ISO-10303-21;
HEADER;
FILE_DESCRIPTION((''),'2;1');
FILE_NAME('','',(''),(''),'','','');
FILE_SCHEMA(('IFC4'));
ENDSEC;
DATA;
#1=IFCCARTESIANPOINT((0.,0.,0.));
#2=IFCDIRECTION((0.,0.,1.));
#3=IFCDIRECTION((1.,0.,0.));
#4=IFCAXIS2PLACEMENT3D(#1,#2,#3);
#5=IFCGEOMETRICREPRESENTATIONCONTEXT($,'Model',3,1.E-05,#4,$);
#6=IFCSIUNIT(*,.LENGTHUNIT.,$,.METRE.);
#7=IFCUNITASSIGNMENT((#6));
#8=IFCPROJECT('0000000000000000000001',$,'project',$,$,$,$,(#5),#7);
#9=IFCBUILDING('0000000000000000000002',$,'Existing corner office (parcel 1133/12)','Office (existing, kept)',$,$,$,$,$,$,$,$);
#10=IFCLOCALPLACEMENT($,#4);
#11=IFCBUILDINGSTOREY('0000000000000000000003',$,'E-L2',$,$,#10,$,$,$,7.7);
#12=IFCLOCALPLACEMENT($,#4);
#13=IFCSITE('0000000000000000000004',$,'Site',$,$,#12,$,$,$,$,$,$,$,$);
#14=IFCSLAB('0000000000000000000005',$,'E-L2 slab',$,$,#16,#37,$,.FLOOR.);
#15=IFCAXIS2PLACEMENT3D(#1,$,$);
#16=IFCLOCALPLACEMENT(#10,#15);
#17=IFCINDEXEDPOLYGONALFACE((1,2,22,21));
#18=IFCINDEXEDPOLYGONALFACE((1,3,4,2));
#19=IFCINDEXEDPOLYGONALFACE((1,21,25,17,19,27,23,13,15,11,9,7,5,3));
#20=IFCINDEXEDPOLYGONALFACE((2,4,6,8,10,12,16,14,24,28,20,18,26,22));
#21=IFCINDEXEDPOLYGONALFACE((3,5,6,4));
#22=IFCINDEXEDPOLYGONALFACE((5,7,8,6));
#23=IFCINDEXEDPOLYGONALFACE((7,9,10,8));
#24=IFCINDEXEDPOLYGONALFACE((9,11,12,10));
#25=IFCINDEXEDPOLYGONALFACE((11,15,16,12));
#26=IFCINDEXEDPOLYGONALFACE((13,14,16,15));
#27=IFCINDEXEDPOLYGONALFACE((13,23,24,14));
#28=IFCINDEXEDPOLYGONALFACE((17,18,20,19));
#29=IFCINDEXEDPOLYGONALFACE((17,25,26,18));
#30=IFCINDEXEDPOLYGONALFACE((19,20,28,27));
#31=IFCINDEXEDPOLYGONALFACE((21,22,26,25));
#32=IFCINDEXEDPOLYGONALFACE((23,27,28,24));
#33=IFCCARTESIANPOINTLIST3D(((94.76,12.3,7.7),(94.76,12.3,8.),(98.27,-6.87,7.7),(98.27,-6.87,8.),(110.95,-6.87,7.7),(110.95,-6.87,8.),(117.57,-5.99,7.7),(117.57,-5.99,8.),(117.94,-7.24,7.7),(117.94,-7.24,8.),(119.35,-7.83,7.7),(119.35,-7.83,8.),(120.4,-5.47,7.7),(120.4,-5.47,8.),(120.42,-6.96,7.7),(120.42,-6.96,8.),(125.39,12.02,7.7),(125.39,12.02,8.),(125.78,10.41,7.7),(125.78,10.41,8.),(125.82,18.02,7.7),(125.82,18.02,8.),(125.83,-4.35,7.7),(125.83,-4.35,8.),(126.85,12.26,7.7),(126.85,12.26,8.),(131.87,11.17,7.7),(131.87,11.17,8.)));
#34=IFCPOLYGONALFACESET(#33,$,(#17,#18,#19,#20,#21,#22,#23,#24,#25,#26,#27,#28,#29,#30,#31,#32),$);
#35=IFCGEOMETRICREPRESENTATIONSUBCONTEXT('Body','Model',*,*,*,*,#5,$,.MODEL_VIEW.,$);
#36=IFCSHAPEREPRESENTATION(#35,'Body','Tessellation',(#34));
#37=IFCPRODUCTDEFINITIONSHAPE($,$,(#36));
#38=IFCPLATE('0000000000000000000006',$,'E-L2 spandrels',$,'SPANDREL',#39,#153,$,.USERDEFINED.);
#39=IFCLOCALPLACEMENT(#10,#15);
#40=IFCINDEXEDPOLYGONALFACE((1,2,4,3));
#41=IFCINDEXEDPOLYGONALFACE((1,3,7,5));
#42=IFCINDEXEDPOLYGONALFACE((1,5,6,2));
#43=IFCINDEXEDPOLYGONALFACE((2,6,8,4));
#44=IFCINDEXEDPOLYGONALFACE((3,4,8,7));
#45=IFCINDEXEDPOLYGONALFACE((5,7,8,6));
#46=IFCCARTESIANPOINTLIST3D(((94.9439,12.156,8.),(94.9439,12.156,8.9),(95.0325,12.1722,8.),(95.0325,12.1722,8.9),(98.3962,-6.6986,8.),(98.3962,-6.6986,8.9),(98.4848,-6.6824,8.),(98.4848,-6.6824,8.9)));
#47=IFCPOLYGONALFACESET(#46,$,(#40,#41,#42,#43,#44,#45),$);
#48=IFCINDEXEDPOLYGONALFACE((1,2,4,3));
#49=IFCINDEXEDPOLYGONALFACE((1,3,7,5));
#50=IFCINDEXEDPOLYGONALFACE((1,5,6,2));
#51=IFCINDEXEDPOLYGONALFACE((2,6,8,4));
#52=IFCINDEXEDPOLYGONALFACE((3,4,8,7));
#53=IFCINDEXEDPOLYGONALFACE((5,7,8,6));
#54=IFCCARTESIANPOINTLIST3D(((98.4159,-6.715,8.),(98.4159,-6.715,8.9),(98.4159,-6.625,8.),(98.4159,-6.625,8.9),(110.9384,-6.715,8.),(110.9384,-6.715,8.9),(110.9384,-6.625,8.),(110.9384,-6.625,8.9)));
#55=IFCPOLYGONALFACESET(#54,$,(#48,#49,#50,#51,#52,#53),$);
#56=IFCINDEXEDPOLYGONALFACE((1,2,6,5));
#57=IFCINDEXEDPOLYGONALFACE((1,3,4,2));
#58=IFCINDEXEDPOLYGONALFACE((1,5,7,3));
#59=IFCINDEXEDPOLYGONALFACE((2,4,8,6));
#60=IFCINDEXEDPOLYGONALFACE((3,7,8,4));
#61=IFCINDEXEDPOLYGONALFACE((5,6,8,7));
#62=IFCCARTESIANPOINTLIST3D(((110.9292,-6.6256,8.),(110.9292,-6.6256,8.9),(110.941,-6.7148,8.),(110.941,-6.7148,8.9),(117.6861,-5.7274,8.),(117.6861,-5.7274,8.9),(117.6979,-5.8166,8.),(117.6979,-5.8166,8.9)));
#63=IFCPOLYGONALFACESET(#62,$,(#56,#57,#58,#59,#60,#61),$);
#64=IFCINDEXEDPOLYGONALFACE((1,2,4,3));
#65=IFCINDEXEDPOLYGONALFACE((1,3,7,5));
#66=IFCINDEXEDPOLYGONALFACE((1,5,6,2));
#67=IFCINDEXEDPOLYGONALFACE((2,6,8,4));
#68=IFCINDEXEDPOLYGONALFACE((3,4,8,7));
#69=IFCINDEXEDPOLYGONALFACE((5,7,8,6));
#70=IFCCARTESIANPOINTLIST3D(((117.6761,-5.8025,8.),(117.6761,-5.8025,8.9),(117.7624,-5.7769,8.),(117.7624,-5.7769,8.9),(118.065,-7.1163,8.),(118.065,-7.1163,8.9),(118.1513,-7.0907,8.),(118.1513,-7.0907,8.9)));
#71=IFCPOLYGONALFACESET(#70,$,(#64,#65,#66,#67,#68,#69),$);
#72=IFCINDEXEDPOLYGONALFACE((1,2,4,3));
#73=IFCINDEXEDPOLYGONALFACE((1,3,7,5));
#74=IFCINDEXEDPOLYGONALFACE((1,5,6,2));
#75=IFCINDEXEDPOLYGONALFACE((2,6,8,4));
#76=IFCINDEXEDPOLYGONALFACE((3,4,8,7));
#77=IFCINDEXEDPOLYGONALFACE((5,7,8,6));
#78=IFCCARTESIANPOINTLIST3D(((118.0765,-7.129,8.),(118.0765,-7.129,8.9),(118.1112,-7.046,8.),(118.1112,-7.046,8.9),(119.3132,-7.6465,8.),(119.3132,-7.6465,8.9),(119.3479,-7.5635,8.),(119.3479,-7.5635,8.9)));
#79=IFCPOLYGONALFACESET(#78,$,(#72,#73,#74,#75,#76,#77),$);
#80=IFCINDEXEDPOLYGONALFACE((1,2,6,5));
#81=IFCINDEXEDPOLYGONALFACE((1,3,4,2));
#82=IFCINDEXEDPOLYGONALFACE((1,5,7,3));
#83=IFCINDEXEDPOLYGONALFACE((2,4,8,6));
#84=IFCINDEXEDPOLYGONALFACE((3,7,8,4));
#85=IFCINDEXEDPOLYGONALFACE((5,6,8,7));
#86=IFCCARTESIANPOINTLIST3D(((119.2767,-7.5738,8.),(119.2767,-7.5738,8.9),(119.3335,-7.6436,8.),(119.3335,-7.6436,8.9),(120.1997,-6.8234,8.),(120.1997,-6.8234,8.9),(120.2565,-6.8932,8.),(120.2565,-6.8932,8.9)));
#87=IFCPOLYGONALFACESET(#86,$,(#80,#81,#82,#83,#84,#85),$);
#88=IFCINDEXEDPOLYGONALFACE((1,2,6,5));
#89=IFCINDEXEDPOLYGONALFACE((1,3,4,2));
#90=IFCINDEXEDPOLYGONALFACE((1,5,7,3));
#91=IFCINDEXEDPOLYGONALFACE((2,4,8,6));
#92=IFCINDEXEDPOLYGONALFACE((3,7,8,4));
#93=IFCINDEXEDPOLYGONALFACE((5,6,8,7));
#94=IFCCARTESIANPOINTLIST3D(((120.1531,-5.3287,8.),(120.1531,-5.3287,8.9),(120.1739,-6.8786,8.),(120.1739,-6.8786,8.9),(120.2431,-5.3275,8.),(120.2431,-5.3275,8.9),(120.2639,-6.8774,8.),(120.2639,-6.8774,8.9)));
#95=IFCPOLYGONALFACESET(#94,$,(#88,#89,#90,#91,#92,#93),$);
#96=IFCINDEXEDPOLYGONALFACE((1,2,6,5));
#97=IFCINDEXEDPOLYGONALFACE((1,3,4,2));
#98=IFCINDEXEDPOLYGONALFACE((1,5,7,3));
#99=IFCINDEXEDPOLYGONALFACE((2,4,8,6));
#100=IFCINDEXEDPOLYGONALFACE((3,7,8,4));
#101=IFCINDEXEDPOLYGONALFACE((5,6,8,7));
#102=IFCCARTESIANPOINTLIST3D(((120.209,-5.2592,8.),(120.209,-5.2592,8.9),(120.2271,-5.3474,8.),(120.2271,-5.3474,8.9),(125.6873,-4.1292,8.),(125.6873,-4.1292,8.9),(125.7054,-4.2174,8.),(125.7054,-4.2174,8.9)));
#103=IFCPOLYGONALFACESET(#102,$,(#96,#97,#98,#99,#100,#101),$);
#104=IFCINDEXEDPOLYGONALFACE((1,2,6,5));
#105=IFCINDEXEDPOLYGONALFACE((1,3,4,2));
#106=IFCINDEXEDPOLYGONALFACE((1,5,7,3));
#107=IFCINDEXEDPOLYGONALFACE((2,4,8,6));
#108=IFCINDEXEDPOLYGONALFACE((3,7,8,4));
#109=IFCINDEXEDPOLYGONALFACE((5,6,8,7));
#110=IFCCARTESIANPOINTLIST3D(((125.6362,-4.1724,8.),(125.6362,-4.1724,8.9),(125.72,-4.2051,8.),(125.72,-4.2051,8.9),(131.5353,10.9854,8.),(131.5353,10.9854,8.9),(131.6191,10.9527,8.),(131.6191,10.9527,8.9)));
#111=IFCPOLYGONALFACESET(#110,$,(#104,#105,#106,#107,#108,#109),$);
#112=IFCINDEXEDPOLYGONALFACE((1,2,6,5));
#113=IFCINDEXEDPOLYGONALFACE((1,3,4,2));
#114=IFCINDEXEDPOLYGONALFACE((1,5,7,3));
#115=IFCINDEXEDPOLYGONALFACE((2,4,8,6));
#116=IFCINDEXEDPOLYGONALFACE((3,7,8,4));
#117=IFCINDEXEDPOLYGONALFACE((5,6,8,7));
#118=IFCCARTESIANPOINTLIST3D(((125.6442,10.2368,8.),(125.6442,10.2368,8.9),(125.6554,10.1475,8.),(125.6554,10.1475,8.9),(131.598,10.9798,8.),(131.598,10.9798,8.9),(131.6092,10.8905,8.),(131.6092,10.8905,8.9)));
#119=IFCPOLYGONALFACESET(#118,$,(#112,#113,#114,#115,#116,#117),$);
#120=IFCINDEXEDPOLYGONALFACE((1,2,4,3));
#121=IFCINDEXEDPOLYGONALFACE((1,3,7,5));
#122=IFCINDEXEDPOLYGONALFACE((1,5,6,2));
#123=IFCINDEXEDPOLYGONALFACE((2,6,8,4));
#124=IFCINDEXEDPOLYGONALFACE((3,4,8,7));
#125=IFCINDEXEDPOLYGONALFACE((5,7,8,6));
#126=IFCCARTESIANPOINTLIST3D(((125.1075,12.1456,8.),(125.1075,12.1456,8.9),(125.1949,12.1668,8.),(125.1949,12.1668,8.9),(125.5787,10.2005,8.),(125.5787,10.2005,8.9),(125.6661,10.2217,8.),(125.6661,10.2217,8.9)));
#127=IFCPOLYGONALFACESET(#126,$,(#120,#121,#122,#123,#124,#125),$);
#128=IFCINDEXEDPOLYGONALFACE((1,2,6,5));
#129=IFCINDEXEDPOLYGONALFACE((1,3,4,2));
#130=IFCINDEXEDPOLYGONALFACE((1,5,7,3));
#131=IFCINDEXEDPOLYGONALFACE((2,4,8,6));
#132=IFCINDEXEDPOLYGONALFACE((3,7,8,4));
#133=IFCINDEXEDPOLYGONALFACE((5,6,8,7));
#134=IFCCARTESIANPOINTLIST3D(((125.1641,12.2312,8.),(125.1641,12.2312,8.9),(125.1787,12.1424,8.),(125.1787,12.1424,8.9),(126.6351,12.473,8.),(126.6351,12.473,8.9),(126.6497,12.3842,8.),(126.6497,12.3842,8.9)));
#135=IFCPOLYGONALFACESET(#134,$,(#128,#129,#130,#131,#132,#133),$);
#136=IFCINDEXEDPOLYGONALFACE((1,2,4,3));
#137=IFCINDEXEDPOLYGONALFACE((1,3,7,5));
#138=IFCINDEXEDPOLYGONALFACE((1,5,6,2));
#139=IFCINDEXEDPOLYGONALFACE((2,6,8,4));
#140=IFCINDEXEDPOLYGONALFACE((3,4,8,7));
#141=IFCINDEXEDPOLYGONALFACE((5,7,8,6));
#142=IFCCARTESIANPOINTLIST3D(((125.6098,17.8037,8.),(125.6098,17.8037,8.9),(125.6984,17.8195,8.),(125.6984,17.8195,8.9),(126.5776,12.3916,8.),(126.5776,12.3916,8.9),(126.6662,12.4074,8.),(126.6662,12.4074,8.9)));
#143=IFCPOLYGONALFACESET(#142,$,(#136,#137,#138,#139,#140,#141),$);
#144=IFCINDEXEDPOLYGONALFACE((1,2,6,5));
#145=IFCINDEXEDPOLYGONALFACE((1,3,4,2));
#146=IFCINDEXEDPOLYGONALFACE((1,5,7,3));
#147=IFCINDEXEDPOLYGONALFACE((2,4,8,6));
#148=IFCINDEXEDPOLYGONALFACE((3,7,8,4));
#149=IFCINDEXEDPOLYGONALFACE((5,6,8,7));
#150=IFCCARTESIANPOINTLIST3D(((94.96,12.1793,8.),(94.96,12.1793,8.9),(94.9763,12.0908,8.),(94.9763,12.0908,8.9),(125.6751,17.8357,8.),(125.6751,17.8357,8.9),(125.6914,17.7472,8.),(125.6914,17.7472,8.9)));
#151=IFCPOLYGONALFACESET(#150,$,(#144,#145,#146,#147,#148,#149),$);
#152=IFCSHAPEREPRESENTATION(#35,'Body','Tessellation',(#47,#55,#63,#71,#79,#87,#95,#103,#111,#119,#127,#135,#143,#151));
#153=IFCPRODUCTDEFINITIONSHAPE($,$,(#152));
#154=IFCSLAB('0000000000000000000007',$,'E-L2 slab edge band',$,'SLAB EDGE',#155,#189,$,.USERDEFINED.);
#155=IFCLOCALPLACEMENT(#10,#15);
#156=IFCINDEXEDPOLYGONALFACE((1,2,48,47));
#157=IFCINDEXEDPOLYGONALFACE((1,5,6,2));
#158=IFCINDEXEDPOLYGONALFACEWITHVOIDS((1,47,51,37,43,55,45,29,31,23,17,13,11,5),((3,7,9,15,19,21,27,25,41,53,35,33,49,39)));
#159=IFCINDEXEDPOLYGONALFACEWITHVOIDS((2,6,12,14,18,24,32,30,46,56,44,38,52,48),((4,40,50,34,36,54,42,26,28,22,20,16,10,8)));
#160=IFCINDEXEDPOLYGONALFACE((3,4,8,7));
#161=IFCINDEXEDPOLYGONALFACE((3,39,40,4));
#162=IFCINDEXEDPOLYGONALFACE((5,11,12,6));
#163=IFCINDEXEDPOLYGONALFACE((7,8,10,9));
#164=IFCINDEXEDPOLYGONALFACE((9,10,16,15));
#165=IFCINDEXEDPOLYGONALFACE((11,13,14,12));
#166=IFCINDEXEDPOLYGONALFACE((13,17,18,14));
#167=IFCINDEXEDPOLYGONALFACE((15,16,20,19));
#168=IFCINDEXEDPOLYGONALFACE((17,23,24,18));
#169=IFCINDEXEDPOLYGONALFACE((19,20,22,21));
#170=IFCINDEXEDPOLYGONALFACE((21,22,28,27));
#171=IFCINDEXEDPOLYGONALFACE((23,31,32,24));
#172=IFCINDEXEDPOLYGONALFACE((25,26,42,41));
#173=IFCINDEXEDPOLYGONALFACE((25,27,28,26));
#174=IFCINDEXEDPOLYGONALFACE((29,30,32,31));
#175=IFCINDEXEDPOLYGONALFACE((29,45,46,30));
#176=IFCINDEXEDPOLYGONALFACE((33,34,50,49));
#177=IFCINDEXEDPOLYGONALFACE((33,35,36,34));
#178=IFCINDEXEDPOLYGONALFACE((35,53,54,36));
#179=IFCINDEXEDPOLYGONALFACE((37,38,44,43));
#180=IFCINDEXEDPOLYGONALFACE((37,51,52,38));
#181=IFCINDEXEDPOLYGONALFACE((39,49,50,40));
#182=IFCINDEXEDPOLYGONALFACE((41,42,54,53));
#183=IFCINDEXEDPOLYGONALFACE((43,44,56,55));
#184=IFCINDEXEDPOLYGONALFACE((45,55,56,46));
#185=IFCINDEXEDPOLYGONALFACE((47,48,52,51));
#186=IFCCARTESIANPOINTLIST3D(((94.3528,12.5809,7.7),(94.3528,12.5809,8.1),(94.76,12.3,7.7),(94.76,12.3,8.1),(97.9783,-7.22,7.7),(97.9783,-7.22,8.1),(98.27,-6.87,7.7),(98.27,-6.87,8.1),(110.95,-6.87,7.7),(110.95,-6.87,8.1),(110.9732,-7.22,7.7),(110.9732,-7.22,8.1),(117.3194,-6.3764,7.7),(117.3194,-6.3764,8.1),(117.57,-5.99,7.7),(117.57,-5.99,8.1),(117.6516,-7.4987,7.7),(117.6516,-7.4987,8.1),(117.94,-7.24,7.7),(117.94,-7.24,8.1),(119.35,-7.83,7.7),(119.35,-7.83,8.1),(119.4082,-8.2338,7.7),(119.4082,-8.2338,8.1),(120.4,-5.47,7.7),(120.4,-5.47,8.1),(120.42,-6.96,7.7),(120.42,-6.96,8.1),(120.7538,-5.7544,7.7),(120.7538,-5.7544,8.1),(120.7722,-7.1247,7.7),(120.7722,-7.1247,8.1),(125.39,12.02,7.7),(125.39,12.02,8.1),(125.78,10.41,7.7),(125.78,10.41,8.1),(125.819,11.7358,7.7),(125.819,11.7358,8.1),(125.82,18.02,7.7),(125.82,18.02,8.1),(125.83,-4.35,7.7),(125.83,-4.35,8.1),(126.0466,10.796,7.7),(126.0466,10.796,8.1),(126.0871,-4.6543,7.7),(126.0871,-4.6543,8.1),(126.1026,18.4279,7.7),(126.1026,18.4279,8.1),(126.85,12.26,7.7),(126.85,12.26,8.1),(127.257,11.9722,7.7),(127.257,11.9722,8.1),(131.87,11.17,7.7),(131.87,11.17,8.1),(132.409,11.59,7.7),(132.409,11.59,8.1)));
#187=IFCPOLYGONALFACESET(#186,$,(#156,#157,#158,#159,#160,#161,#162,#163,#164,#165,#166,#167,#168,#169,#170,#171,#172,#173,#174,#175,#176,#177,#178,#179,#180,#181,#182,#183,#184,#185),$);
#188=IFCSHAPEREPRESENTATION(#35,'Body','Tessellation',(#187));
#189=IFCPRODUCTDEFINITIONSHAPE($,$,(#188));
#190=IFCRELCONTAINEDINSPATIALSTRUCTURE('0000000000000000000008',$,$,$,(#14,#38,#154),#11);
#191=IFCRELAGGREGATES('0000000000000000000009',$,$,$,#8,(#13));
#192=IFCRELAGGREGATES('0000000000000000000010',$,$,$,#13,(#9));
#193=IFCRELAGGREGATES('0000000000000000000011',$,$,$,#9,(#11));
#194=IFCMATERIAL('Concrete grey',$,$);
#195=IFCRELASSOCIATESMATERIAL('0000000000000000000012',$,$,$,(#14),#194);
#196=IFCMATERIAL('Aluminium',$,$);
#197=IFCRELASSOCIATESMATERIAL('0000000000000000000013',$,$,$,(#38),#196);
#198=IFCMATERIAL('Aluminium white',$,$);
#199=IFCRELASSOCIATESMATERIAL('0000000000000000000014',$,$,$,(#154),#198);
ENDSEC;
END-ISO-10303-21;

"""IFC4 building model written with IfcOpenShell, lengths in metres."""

from ifc_helpers import new_model, si_unit, frame, origin_with_axes, place, context, subcontext, project, spatial, polyline, outline, extrude, material, element, save


model = new_model("IFC4")

# Units and contexts
model_context = context("Model", 3, precision=1e-05, world=origin_with_axes())
body_context = subcontext(model_context, "Body", "Model", "MODEL_VIEW")
ifc_project = project(units=[si_unit("LENGTHUNIT", "METRE")], contexts=[model_context])

# Site, building, storey
site_placement = place(None, origin_with_axes())
site = spatial("IfcSite", under=ifc_project, at=site_placement, Name="Site")
building = spatial("IfcBuilding", under=site, Name="Existing corner office (parcel 1133/12)", Description="Office (existing, kept)")
storey_placement = place(None, origin_with_axes())
storey = spatial("IfcBuildingStorey", under=building, at=storey_placement, Name="E-L2", Elevation=7.7)

# Shared definitions
ifc_material_1 = material(Name="Aluminium")

# Slab
ifc_material_2 = material(Name="Concrete grey")
slab_1_placement = place(storey_placement, origin_with_axes())
element("IfcSlab", 1, at=slab_1_placement, inside=storey, material=ifc_material_2, Name="E-L2 slab", PredefinedType="FLOOR", context=body_context, shape_type="SweptSolid", body=[
    extrude(outline(polyline([(94.76, 12.3), (98.27, -6.87), (110.95, -6.87), (117.57, -5.99), (117.94, -7.24), (119.35, -7.83), (120.42, -6.96), (120.4, -5.47), (125.83, -4.35), (131.87, 11.17), (125.78, 10.41), (125.39, 12.02), (126.85, 12.26), (125.82, 18.02), (94.76, 12.3)])), frame((0.0, 0.0, 7.7), z_axis=(0.0, 0.0, 1.0), x_axis=(1.0, 0.0, 0.0)), (0.0, 0.0, 1.0), 0.3),
])

# Plate
plate_placement = place(storey_placement, origin_with_axes())
element("IfcPlate", 2, at=plate_placement, inside=storey, material=ifc_material_1, Name="E-L2 spandrels", ObjectType="SPANDREL", PredefinedType="USERDEFINED", context=body_context, shape_type="SweptSolid", body=[
    extrude(outline(polyline([(94.9439, 12.156), (98.3962, -6.6986), (98.4848, -6.6824), (95.0325, 12.1722), (94.9439, 12.156)])), frame((0.0, 0.0, 8.0), z_axis=(0.0, 0.0, 1.0), x_axis=(1.0, 0.0, 0.0)), (0.0, 0.0, 1.0), 0.9),
    extrude(outline(polyline([(98.4159, -6.715), (110.9384, -6.715), (110.9384, -6.625), (98.4159, -6.625), (98.4159, -6.715)])), frame((0.0, 0.0, 8.0), z_axis=(0.0, 0.0, 1.0), x_axis=(1.0, 0.0, 0.0)), (0.0, 0.0, 1.0), 0.9),
    extrude(outline(polyline([(110.941, -6.7148), (117.6979, -5.8166), (117.6861, -5.7274), (110.9292, -6.6256), (110.941, -6.7148)])), frame((0.0, 0.0, 8.0), z_axis=(0.0, 0.0, 1.0), x_axis=(1.0, 0.0, 0.0)), (0.0, 0.0, 1.0), 0.9),
    extrude(outline(polyline([(117.6761, -5.8025), (118.065, -7.1163), (118.1513, -7.0907), (117.7624, -5.7769), (117.6761, -5.8025)])), frame((0.0, 0.0, 8.0), z_axis=(0.0, 0.0, 1.0), x_axis=(1.0, 0.0, 0.0)), (0.0, 0.0, 1.0), 0.9),
    extrude(outline(polyline([(118.0765, -7.129), (119.3132, -7.6465), (119.3479, -7.5635), (118.1112, -7.046), (118.0765, -7.129)])), frame((0.0, 0.0, 8.0), z_axis=(0.0, 0.0, 1.0), x_axis=(1.0, 0.0, 0.0)), (0.0, 0.0, 1.0), 0.9),
    extrude(outline(polyline([(119.3335, -7.6436), (120.2565, -6.8932), (120.1997, -6.8234), (119.2767, -7.5738), (119.3335, -7.6436)])), frame((0.0, 0.0, 8.0), z_axis=(0.0, 0.0, 1.0), x_axis=(1.0, 0.0, 0.0)), (0.0, 0.0, 1.0), 0.9),
    extrude(outline(polyline([(120.2639, -6.8774), (120.2431, -5.3275), (120.1531, -5.3287), (120.1739, -6.8786), (120.2639, -6.8774)])), frame((0.0, 0.0, 8.0), z_axis=(0.0, 0.0, 1.0), x_axis=(1.0, 0.0, 0.0)), (0.0, 0.0, 1.0), 0.9),
    extrude(outline(polyline([(120.2271, -5.3474), (125.7054, -4.2174), (125.6873, -4.1292), (120.209, -5.2592), (120.2271, -5.3474)])), frame((0.0, 0.0, 8.0), z_axis=(0.0, 0.0, 1.0), x_axis=(1.0, 0.0, 0.0)), (0.0, 0.0, 1.0), 0.9),
    extrude(outline(polyline([(125.72, -4.2051), (131.6191, 10.9527), (131.5353, 10.9854), (125.6362, -4.1724), (125.72, -4.2051)])), frame((0.0, 0.0, 8.0), z_axis=(0.0, 0.0, 1.0), x_axis=(1.0, 0.0, 0.0)), (0.0, 0.0, 1.0), 0.9),
    extrude(outline(polyline([(131.598, 10.9798), (125.6442, 10.2368), (125.6554, 10.1475), (131.6092, 10.8905), (131.598, 10.9798)])), frame((0.0, 0.0, 8.0), z_axis=(0.0, 0.0, 1.0), x_axis=(1.0, 0.0, 0.0)), (0.0, 0.0, 1.0), 0.9),
    extrude(outline(polyline([(125.6661, 10.2217), (125.1949, 12.1668), (125.1075, 12.1456), (125.5787, 10.2005), (125.6661, 10.2217)])), frame((0.0, 0.0, 8.0), z_axis=(0.0, 0.0, 1.0), x_axis=(1.0, 0.0, 0.0)), (0.0, 0.0, 1.0), 0.9),
    extrude(outline(polyline([(125.1787, 12.1424), (126.6497, 12.3842), (126.6351, 12.473), (125.1641, 12.2312), (125.1787, 12.1424)])), frame((0.0, 0.0, 8.0), z_axis=(0.0, 0.0, 1.0), x_axis=(1.0, 0.0, 0.0)), (0.0, 0.0, 1.0), 0.9),
    extrude(outline(polyline([(126.6662, 12.4074), (125.6984, 17.8195), (125.6098, 17.8037), (126.5776, 12.3916), (126.6662, 12.4074)])), frame((0.0, 0.0, 8.0), z_axis=(0.0, 0.0, 1.0), x_axis=(1.0, 0.0, 0.0)), (0.0, 0.0, 1.0), 0.9),
    extrude(outline(polyline([(125.6751, 17.8357), (94.96, 12.1793), (94.9763, 12.0908), (125.6914, 17.7472), (125.6751, 17.8357)])), frame((0.0, 0.0, 8.0), z_axis=(0.0, 0.0, 1.0), x_axis=(1.0, 0.0, 0.0)), (0.0, 0.0, 1.0), 0.9),
])

# Slab
ifc_material_3 = material(Name="Aluminium white")
slab_2_placement = place(storey_placement, origin_with_axes())
element("IfcSlab", 3, at=slab_2_placement, inside=storey, material=ifc_material_3, Name="E-L2 slab edge band", ObjectType="SLAB EDGE", PredefinedType="USERDEFINED", context=body_context, shape_type="SweptSolid", body=[
    extrude(outline(polyline([(94.3528, 12.5809), (97.9783, -7.22), (110.9732, -7.22), (117.3194, -6.3764), (117.6516, -7.4987), (119.4082, -8.2338), (120.7722, -7.1247), (120.7538, -5.7544), (126.0871, -4.6543), (132.409, 11.59), (126.0466, 10.796), (125.819, 11.7358), (127.257, 11.9722), (126.1026, 18.4279), (94.3528, 12.5809)]), holes=[polyline([(94.76, 12.3), (98.27, -6.87), (110.95, -6.87), (117.57, -5.99), (117.94, -7.24), (119.35, -7.83), (120.42, -6.96), (120.4, -5.47), (125.83, -4.35), (131.87, 11.17), (125.78, 10.41), (125.39, 12.02), (126.85, 12.26), (125.82, 18.02), (94.76, 12.3)])]), frame((0.0, 0.0, 7.7), z_axis=(0.0, 0.0, 1.0), x_axis=(1.0, 0.0, 0.0)), (0.0, 0.0, 1.0), 0.4),
])

save(model, "model.ifc")
